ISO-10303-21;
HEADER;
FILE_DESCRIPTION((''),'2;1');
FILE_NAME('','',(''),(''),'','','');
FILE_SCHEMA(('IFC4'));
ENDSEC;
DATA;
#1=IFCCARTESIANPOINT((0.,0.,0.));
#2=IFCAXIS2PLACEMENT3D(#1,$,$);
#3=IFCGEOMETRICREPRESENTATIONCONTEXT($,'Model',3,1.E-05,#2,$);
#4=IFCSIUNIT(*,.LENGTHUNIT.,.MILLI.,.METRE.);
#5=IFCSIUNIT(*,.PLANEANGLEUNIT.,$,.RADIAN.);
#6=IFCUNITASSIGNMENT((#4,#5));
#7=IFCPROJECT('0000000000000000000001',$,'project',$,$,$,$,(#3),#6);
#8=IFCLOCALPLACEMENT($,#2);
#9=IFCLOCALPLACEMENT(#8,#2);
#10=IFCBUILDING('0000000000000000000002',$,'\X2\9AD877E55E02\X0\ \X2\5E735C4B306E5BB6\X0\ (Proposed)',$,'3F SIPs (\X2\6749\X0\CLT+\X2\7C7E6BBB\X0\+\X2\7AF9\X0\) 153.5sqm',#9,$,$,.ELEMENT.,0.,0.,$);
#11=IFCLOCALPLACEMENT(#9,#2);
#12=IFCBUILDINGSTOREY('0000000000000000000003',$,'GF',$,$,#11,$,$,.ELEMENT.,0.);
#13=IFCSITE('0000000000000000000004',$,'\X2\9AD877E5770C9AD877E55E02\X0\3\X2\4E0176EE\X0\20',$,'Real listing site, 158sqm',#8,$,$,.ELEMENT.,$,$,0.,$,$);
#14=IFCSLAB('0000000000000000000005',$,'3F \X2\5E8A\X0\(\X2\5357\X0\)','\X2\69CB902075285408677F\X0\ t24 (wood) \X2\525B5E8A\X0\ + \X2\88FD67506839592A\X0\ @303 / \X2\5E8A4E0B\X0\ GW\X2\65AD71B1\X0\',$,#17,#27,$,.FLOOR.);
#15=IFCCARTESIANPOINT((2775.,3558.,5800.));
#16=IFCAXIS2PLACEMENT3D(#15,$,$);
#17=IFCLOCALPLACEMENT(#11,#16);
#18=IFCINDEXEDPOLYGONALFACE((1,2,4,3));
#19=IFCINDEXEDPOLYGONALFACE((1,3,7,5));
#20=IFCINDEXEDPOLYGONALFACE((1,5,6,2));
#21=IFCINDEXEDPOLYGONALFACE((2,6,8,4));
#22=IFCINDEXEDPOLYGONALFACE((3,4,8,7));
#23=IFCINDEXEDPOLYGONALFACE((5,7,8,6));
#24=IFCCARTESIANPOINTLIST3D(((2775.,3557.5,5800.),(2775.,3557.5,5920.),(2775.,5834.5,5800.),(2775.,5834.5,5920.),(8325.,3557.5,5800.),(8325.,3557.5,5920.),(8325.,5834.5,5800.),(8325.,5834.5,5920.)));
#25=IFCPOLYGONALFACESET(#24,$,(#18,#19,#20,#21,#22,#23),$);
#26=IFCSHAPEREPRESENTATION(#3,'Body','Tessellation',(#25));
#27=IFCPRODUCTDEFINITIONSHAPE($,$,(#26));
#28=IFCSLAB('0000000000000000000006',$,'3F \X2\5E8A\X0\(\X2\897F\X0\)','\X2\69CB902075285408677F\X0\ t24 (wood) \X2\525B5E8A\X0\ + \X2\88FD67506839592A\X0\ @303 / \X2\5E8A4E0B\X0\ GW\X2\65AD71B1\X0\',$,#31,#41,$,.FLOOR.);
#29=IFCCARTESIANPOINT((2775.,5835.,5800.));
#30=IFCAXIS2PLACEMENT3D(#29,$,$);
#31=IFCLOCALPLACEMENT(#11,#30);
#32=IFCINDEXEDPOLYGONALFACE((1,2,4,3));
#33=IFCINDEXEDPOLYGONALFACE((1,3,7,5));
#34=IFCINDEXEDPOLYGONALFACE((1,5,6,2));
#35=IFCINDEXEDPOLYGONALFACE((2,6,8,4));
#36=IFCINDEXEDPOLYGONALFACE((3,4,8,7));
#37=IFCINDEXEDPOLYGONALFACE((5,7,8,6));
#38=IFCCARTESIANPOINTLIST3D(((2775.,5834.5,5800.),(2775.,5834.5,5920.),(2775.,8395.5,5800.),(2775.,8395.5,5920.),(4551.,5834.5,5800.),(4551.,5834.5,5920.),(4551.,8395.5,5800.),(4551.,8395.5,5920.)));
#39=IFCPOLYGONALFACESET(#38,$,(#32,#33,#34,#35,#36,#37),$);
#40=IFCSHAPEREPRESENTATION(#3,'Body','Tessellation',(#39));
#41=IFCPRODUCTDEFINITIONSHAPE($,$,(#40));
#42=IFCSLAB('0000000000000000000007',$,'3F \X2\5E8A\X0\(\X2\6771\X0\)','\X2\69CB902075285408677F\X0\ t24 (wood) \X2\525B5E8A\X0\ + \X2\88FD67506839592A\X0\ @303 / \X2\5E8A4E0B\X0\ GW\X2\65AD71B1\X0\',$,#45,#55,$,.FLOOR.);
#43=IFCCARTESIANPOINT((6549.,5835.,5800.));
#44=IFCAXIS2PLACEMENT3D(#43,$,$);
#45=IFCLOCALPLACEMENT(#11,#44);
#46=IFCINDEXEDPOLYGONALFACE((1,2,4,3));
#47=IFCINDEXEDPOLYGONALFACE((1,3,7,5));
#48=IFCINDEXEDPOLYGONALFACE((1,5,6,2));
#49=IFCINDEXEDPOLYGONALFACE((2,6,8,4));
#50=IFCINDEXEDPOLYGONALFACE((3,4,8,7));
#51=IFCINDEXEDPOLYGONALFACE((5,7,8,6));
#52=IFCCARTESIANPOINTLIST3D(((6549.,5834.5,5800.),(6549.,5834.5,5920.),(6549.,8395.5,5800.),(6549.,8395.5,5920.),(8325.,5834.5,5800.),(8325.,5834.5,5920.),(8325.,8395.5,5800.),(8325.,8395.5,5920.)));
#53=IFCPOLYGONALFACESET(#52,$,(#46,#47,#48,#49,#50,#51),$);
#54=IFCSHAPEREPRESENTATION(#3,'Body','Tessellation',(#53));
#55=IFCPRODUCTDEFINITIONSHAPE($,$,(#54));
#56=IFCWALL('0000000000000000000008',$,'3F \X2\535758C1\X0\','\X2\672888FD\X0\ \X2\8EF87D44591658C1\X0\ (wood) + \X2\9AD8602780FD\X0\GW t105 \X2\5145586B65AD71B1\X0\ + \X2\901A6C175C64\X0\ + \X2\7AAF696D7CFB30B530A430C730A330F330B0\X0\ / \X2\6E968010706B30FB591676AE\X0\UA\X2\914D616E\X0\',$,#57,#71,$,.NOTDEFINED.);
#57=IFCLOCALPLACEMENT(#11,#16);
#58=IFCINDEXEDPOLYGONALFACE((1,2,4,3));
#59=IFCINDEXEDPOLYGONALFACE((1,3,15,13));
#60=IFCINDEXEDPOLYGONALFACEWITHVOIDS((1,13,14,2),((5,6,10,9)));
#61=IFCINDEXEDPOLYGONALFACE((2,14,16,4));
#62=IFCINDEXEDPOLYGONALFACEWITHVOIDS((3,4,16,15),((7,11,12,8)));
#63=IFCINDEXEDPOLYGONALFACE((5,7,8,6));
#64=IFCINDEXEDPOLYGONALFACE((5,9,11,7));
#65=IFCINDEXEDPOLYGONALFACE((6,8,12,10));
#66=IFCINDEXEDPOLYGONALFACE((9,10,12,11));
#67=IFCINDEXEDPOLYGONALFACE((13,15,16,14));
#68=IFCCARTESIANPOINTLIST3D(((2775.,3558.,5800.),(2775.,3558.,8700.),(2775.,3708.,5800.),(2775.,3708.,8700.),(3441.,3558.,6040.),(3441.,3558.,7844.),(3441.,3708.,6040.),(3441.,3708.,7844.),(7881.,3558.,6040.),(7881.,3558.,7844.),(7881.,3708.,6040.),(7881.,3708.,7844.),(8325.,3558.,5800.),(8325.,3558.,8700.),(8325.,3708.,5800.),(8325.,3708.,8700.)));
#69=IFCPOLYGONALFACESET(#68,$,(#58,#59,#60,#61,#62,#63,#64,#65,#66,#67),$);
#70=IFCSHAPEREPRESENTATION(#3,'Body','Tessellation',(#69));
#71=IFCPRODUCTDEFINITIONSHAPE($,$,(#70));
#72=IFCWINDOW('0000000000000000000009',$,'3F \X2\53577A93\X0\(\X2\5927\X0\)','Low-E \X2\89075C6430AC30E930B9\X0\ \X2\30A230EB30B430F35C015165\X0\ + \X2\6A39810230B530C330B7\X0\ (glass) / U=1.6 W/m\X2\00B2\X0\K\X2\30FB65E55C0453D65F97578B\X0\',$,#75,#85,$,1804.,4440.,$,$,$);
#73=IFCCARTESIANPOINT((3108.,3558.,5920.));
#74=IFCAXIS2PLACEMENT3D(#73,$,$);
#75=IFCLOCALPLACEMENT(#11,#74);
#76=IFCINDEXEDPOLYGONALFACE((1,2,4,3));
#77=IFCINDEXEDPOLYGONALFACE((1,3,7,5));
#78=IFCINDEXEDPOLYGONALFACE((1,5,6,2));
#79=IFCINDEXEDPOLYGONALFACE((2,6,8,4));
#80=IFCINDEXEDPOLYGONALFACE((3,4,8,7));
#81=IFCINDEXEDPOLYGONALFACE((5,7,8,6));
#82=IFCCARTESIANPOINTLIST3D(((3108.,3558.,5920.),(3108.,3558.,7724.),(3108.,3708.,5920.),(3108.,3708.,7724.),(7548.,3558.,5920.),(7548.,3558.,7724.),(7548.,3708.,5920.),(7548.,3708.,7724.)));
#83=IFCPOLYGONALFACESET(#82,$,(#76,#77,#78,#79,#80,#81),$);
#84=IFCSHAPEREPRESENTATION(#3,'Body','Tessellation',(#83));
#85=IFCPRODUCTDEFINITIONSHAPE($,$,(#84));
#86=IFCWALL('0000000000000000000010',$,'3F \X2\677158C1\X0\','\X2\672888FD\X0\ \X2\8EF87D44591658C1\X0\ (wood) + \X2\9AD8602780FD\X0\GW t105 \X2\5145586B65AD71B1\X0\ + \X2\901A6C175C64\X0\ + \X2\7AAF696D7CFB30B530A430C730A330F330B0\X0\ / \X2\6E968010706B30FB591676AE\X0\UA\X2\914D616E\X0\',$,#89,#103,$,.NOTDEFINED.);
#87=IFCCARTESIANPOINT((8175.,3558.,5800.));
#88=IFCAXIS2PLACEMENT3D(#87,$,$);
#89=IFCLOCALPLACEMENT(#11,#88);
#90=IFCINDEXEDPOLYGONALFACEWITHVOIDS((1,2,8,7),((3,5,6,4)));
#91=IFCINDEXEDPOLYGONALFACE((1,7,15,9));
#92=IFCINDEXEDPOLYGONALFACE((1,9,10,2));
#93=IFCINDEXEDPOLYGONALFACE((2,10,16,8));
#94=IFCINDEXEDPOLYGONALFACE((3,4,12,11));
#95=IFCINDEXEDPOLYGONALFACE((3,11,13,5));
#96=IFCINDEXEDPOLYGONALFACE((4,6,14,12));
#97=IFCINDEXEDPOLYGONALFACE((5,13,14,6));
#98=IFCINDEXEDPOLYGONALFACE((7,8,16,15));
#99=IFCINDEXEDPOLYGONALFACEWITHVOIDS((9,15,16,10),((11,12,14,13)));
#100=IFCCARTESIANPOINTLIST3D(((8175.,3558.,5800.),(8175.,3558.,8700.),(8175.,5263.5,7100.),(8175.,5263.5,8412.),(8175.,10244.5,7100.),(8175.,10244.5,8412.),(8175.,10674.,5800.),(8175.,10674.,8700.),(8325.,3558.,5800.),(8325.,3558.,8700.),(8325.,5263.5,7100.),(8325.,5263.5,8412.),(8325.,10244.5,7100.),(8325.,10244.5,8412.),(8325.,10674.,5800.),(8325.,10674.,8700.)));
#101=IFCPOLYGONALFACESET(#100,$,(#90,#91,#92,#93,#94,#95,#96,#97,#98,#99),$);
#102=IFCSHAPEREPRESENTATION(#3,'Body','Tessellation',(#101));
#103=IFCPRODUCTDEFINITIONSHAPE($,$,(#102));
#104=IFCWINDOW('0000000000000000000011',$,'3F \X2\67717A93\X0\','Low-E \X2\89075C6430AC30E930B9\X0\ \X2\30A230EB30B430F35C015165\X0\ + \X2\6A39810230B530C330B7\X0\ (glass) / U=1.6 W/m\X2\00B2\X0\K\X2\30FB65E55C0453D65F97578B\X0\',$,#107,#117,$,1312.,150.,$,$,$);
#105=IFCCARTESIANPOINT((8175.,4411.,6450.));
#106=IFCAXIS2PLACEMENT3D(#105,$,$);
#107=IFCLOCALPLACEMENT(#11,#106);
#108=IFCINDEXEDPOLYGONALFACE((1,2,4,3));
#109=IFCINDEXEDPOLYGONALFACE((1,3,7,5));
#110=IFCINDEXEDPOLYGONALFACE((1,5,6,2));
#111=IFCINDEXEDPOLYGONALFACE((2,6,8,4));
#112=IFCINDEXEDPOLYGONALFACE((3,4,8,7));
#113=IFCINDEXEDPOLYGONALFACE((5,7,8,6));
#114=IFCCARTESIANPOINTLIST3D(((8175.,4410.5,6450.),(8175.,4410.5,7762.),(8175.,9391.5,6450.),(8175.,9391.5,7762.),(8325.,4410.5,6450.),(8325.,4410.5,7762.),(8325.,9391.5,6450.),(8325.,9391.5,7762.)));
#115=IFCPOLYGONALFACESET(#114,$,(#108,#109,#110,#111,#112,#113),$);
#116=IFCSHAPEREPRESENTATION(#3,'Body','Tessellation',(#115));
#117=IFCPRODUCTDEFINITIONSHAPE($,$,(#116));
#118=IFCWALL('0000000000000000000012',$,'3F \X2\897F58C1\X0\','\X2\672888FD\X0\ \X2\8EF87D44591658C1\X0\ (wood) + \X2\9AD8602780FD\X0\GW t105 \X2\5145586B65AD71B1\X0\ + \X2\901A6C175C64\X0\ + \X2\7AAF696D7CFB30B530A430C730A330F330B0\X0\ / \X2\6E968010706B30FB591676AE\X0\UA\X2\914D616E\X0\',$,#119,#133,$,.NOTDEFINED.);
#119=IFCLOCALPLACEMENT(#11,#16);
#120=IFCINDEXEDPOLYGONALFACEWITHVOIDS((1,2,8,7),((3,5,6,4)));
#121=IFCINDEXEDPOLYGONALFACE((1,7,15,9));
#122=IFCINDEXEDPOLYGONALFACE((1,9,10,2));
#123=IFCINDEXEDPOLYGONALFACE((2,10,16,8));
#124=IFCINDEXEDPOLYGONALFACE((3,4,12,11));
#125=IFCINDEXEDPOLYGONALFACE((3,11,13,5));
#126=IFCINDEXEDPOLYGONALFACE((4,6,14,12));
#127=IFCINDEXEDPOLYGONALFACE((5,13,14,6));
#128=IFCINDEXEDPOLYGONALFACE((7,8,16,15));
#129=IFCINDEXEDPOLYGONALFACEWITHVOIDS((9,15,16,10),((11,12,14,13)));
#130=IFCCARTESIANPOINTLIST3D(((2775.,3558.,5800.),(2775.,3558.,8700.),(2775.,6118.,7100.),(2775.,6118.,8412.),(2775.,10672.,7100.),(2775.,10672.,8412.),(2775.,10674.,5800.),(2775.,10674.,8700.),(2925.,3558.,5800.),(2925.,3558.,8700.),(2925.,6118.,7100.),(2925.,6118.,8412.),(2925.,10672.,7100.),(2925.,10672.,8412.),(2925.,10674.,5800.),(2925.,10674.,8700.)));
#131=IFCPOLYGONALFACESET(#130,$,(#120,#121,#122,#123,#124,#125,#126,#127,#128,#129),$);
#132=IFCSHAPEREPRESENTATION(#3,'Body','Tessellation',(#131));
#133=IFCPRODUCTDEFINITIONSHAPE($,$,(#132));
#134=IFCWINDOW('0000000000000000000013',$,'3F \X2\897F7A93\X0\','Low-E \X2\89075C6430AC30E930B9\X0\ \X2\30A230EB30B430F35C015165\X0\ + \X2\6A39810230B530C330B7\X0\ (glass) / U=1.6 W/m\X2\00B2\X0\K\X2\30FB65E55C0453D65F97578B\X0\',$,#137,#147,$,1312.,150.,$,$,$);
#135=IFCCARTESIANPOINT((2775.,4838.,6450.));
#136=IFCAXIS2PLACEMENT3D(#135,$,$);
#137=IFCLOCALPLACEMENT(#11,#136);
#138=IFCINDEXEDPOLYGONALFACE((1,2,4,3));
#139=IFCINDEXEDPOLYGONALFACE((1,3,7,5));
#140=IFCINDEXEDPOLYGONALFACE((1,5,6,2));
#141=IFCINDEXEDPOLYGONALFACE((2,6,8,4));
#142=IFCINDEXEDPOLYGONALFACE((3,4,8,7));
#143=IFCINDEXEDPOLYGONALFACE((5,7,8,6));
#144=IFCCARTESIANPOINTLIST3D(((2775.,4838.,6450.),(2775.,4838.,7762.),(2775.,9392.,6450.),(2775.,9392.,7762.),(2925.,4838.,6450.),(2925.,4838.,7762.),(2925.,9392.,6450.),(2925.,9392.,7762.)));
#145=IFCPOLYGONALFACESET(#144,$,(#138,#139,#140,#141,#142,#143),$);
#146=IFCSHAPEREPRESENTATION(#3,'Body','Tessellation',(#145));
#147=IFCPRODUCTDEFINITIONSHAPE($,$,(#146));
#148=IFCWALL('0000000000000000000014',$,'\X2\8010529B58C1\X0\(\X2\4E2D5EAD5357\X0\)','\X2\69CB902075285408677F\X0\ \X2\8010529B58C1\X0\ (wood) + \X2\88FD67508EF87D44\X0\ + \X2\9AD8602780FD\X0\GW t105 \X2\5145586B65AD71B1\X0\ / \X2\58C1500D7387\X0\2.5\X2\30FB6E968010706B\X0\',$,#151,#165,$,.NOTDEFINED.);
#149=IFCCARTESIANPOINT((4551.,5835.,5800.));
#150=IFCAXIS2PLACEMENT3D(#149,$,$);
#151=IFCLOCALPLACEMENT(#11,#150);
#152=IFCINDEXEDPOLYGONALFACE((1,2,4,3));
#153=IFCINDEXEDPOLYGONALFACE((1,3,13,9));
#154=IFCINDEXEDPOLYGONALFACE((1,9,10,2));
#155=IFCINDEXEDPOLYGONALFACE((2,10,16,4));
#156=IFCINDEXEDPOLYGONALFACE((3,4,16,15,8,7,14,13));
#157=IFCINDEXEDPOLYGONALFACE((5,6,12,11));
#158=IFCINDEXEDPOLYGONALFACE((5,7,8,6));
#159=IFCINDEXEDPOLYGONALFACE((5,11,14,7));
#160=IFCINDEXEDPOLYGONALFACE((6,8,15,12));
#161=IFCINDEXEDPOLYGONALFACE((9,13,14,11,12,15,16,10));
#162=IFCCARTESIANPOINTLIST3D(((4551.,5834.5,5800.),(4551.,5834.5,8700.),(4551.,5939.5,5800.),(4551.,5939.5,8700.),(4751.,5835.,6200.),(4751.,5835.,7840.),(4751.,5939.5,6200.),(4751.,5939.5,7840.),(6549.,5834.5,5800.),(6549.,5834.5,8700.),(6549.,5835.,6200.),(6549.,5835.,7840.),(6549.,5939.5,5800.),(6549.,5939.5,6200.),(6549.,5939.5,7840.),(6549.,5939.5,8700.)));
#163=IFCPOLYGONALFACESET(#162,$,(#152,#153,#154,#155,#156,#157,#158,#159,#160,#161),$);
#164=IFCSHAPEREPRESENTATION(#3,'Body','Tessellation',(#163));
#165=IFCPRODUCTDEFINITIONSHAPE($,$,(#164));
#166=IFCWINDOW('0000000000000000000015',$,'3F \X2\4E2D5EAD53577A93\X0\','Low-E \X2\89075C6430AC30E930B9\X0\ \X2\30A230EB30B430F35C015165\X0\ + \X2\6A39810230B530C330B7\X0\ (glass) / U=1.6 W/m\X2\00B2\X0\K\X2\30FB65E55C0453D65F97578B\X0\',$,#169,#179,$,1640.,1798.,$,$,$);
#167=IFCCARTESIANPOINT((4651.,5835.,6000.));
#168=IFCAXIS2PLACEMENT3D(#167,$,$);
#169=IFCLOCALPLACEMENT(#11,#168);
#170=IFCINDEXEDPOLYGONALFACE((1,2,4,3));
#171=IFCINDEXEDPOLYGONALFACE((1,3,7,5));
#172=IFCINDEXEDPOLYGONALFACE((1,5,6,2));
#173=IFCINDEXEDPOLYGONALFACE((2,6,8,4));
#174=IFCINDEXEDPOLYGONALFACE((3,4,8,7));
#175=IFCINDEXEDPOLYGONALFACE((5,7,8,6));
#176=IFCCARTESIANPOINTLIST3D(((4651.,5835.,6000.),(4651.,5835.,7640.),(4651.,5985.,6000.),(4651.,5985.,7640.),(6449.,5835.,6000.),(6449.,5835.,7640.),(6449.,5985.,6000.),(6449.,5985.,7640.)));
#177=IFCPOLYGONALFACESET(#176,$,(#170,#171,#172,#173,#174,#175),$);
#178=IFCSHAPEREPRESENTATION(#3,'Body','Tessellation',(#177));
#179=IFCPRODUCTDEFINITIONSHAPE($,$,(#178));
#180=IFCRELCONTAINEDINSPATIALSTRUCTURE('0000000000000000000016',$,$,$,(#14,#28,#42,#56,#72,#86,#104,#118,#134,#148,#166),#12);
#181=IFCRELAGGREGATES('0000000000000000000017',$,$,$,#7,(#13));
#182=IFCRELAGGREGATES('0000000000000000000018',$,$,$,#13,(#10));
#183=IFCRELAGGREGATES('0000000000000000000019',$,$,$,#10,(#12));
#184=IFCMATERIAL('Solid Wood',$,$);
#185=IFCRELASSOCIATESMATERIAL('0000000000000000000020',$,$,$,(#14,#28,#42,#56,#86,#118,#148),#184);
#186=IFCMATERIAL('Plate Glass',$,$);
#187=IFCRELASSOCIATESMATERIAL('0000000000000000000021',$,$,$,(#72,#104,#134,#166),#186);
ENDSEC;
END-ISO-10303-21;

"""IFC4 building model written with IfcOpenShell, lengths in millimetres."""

from ifc_helpers import new_model, si_unit, frame, frame_2d, origin, place, context, project, spatial, rectangle, extrude, material, element, fill, save


model = new_model("IFC4")

# Units and contexts
model_context = context("Model", 3, precision=1e-05, world=origin())
ifc_project = project(units=[si_unit("LENGTHUNIT", "METRE", prefix="MILLI"), si_unit("PLANEANGLEUNIT", "RADIAN")], contexts=[model_context])

# Site, building, storey
site_placement = place(None, origin())
site = spatial("IfcSite", under=ifc_project, at=site_placement, Name="高知県高知市3丁目20", ObjectType="Real listing site, 158sqm", CompositionType="ELEMENT", RefElevation=0.0)
building_placement = place(site_placement, origin())
building = spatial("IfcBuilding", under=site, at=building_placement, Name="高知市 平屋の家 (Proposed)", ObjectType="3F SIPs (杉CLT+籾殻+竹) 153.5sqm", CompositionType="ELEMENT", ElevationOfRefHeight=0.0, ElevationOfTerrain=0.0)
storey_placement = place(building_placement, origin())
storey = spatial("IfcBuildingStorey", under=building, at=storey_placement, Name="GF", CompositionType="ELEMENT", Elevation=0.0)

# Slabs
ifc_material_1 = material(Name="Solid Wood")
slab_1_placement = place(storey_placement, frame((2775.0, 3558.0, 5800.0)))
element("IfcSlab", 1, at=slab_1_placement, inside=storey, material=ifc_material_1, Name="3F 床(南)", Description="構造用合板 t24 (wood) 剛床 + 製材根太 @303 / 床下 GW断熱", PredefinedType="FLOOR", context=model_context, shape_type="SweptSolid", body=[
    extrude(rectangle(XDim=5550.0, YDim=2277.0, at=frame_2d((2775.0, 1138.0))), frame((2775.0, 3558.0, 5800.0)), (0.0, 0.0, 1.0), 120.0),
])
slab_2_placement = place(storey_placement, frame((2775.0, 5835.0, 5800.0)))
element("IfcSlab", 2, at=slab_2_placement, inside=storey, material=ifc_material_1, Name="3F 床(西)", Description="構造用合板 t24 (wood) 剛床 + 製材根太 @303 / 床下 GW断熱", PredefinedType="FLOOR", context=model_context, shape_type="SweptSolid", body=[
    extrude(rectangle(XDim=1776.0, YDim=2561.0, at=frame_2d((888.0, 1280.0))), frame((2775.0, 5835.0, 5800.0)), (0.0, 0.0, 1.0), 120.0),
])
slab_3_placement = place(storey_placement, frame((6549.0, 5835.0, 5800.0)))
element("IfcSlab", 3, at=slab_3_placement, inside=storey, material=ifc_material_1, Name="3F 床(東)", Description="構造用合板 t24 (wood) 剛床 + 製材根太 @303 / 床下 GW断熱", PredefinedType="FLOOR", context=model_context, shape_type="SweptSolid", body=[
    extrude(rectangle(XDim=1776.0, YDim=2561.0, at=frame_2d((888.0, 1280.0))), frame((6549.0, 5835.0, 5800.0)), (0.0, 0.0, 1.0), 120.0),
])

# Walls, openings, windows
wall_1_placement = place(storey_placement, frame((2775.0, 3558.0, 5800.0)))
wall_1 = element("IfcWall", 4, at=wall_1_placement, inside=storey, material=ifc_material_1, Name="3F 南壁", Description="木製 軸組外壁 (wood) + 高性能GW t105 充填断熱 + 通気層 + 窯業系サイディング / 準耐火・外皮UA配慮", PredefinedType="NOTDEFINED", context=model_context, shape_type="SweptSolid", body=[
    extrude(rectangle(XDim=5550.0, YDim=150.0, at=frame_2d((2775.0, 75.0))), frame((2775.0, 3558.0, 5800.0)), (0.0, 0.0, 1.0), 2900.0),
])
opening_1_placement = place(storey_placement, frame((3108.0, 3558.0, 5920.0)))
opening_1 = element("IfcOpeningElement", 5, at=opening_1_placement, cuts=wall_1, PredefinedType="NOTDEFINED", context=model_context, shape_type="SweptSolid", body=[
    extrude(rectangle(XDim=4440.0, YDim=150.0, at=frame_2d((2220.0, 75.0))), frame((3108.0, 3558.0, 5920.0)), (0.0, 0.0, 1.0), 1804.0),
])
ifc_material_2 = material(Name="Plate Glass")
window_1_placement = place(storey_placement, frame((3108.0, 3558.0, 5920.0)))
window_1 = element("IfcWindow", 6, at=window_1_placement, inside=storey, material=ifc_material_2, Name="3F 南窓(大)", Description="Low-E 複層ガラス アルゴン封入 + 樹脂サッシ (glass) / U=1.6 W/m²K・日射取得型", OverallHeight=1804.0, OverallWidth=4440.0, context=model_context, shape_type="SweptSolid", body=[
    extrude(rectangle(XDim=4440.0, YDim=150.0, at=frame_2d((2220.0, 75.0))), frame((3108.0, 3558.0, 5920.0)), (0.0, 0.0, 1.0), 1804.0),
])
fill(opening_1, window_1)
wall_2_placement = place(storey_placement, frame((8175.0, 3558.0, 5800.0)))
wall_2 = element("IfcWall", 7, at=wall_2_placement, inside=storey, material=ifc_material_1, Name="3F 東壁", Description="木製 軸組外壁 (wood) + 高性能GW t105 充填断熱 + 通気層 + 窯業系サイディング / 準耐火・外皮UA配慮", PredefinedType="NOTDEFINED", context=model_context, shape_type="SweptSolid", body=[
    extrude(rectangle(XDim=150.0, YDim=7116.0, at=frame_2d((75.0, 3558.0))), frame((8175.0, 3558.0, 5800.0)), (0.0, 0.0, 1.0), 2900.0),
])
opening_2_placement = place(storey_placement, frame((8175.0, 4411.0, 6450.0)))
opening_2 = element("IfcOpeningElement", 8, at=opening_2_placement, cuts=wall_2, PredefinedType="NOTDEFINED", context=model_context, shape_type="SweptSolid", body=[
    extrude(rectangle(XDim=150.0, YDim=4981.0, at=frame_2d((75.0, 2490.0))), frame((8175.0, 4411.0, 6450.0)), (0.0, 0.0, 1.0), 1312.0),
])
window_2_placement = place(storey_placement, frame((8175.0, 4411.0, 6450.0)))
window_2 = element("IfcWindow", 9, at=window_2_placement, inside=storey, material=ifc_material_2, Name="3F 東窓", Description="Low-E 複層ガラス アルゴン封入 + 樹脂サッシ (glass) / U=1.6 W/m²K・日射取得型", OverallHeight=1312.0, OverallWidth=150.0, context=model_context, shape_type="SweptSolid", body=[
    extrude(rectangle(XDim=150.0, YDim=4981.0, at=frame_2d((75.0, 2490.0))), frame((8175.0, 4411.0, 6450.0)), (0.0, 0.0, 1.0), 1312.0),
])
fill(opening_2, window_2)
wall_3_placement = place(storey_placement, frame((2775.0, 3558.0, 5800.0)))
wall_3 = element("IfcWall", 10, at=wall_3_placement, inside=storey, material=ifc_material_1, Name="3F 西壁", Description="木製 軸組外壁 (wood) + 高性能GW t105 充填断熱 + 通気層 + 窯業系サイディング / 準耐火・外皮UA配慮", PredefinedType="NOTDEFINED", context=model_context, shape_type="SweptSolid", body=[
    extrude(rectangle(XDim=150.0, YDim=7116.0, at=frame_2d((75.0, 3558.0))), frame((2775.0, 3558.0, 5800.0)), (0.0, 0.0, 1.0), 2900.0),
])
opening_3_placement = place(storey_placement, frame((2775.0, 4838.0, 6450.0)))
opening_3 = element("IfcOpeningElement", 11, at=opening_3_placement, cuts=wall_3, PredefinedType="NOTDEFINED", context=model_context, shape_type="SweptSolid", body=[
    extrude(rectangle(XDim=150.0, YDim=4554.0, at=frame_2d((75.0, 2277.0))), frame((2775.0, 4838.0, 6450.0)), (0.0, 0.0, 1.0), 1312.0),
])
window_3_placement = place(storey_placement, frame((2775.0, 4838.0, 6450.0)))
window_3 = element("IfcWindow", 12, at=window_3_placement, inside=storey, material=ifc_material_2, Name="3F 西窓", Description="Low-E 複層ガラス アルゴン封入 + 樹脂サッシ (glass) / U=1.6 W/m²K・日射取得型", OverallHeight=1312.0, OverallWidth=150.0, context=model_context, shape_type="SweptSolid", body=[
    extrude(rectangle(XDim=150.0, YDim=4554.0, at=frame_2d((75.0, 2277.0))), frame((2775.0, 4838.0, 6450.0)), (0.0, 0.0, 1.0), 1312.0),
])
fill(opening_3, window_3)
wall_4_placement = place(storey_placement, frame((4551.0, 5835.0, 5800.0)))
wall_4 = element("IfcWall", 13, at=wall_4_placement, inside=storey, material=ifc_material_1, Name="耐力壁(中庭南)", Description="構造用合板 耐力壁 (wood) + 製材軸組 + 高性能GW t105 充填断熱 / 壁倍率2.5・準耐火", PredefinedType="NOTDEFINED", context=model_context, shape_type="SweptSolid", body=[
    extrude(rectangle(XDim=1998.0, YDim=105.0, at=frame_2d((999.0, 52.0))), frame((4551.0, 5835.0, 5800.0)), (0.0, 0.0, 1.0), 2900.0),
])
opening_4_placement = place(storey_placement, frame((4651.0, 5835.0, 6000.0)))
opening_4 = element("IfcOpeningElement", 14, at=opening_4_placement, cuts=wall_4, PredefinedType="NOTDEFINED", context=model_context, shape_type="SweptSolid", body=[
    extrude(rectangle(XDim=1798.0, YDim=150.0, at=frame_2d((899.0, 75.0))), frame((4651.0, 5835.0, 6000.0)), (0.0, 0.0, 1.0), 1640.0),
])
window_4_placement = place(storey_placement, frame((4651.0, 5835.0, 6000.0)))
window_4 = element("IfcWindow", 15, at=window_4_placement, inside=storey, material=ifc_material_2, Name="3F 中庭南窓", Description="Low-E 複層ガラス アルゴン封入 + 樹脂サッシ (glass) / U=1.6 W/m²K・日射取得型", OverallHeight=1640.0, OverallWidth=1798.0, context=model_context, shape_type="SweptSolid", body=[
    extrude(rectangle(XDim=1798.0, YDim=150.0, at=frame_2d((899.0, 75.0))), frame((4651.0, 5835.0, 6000.0)), (0.0, 0.0, 1.0), 1640.0),
])
fill(opening_4, window_4)

save(model, "model.ifc")
